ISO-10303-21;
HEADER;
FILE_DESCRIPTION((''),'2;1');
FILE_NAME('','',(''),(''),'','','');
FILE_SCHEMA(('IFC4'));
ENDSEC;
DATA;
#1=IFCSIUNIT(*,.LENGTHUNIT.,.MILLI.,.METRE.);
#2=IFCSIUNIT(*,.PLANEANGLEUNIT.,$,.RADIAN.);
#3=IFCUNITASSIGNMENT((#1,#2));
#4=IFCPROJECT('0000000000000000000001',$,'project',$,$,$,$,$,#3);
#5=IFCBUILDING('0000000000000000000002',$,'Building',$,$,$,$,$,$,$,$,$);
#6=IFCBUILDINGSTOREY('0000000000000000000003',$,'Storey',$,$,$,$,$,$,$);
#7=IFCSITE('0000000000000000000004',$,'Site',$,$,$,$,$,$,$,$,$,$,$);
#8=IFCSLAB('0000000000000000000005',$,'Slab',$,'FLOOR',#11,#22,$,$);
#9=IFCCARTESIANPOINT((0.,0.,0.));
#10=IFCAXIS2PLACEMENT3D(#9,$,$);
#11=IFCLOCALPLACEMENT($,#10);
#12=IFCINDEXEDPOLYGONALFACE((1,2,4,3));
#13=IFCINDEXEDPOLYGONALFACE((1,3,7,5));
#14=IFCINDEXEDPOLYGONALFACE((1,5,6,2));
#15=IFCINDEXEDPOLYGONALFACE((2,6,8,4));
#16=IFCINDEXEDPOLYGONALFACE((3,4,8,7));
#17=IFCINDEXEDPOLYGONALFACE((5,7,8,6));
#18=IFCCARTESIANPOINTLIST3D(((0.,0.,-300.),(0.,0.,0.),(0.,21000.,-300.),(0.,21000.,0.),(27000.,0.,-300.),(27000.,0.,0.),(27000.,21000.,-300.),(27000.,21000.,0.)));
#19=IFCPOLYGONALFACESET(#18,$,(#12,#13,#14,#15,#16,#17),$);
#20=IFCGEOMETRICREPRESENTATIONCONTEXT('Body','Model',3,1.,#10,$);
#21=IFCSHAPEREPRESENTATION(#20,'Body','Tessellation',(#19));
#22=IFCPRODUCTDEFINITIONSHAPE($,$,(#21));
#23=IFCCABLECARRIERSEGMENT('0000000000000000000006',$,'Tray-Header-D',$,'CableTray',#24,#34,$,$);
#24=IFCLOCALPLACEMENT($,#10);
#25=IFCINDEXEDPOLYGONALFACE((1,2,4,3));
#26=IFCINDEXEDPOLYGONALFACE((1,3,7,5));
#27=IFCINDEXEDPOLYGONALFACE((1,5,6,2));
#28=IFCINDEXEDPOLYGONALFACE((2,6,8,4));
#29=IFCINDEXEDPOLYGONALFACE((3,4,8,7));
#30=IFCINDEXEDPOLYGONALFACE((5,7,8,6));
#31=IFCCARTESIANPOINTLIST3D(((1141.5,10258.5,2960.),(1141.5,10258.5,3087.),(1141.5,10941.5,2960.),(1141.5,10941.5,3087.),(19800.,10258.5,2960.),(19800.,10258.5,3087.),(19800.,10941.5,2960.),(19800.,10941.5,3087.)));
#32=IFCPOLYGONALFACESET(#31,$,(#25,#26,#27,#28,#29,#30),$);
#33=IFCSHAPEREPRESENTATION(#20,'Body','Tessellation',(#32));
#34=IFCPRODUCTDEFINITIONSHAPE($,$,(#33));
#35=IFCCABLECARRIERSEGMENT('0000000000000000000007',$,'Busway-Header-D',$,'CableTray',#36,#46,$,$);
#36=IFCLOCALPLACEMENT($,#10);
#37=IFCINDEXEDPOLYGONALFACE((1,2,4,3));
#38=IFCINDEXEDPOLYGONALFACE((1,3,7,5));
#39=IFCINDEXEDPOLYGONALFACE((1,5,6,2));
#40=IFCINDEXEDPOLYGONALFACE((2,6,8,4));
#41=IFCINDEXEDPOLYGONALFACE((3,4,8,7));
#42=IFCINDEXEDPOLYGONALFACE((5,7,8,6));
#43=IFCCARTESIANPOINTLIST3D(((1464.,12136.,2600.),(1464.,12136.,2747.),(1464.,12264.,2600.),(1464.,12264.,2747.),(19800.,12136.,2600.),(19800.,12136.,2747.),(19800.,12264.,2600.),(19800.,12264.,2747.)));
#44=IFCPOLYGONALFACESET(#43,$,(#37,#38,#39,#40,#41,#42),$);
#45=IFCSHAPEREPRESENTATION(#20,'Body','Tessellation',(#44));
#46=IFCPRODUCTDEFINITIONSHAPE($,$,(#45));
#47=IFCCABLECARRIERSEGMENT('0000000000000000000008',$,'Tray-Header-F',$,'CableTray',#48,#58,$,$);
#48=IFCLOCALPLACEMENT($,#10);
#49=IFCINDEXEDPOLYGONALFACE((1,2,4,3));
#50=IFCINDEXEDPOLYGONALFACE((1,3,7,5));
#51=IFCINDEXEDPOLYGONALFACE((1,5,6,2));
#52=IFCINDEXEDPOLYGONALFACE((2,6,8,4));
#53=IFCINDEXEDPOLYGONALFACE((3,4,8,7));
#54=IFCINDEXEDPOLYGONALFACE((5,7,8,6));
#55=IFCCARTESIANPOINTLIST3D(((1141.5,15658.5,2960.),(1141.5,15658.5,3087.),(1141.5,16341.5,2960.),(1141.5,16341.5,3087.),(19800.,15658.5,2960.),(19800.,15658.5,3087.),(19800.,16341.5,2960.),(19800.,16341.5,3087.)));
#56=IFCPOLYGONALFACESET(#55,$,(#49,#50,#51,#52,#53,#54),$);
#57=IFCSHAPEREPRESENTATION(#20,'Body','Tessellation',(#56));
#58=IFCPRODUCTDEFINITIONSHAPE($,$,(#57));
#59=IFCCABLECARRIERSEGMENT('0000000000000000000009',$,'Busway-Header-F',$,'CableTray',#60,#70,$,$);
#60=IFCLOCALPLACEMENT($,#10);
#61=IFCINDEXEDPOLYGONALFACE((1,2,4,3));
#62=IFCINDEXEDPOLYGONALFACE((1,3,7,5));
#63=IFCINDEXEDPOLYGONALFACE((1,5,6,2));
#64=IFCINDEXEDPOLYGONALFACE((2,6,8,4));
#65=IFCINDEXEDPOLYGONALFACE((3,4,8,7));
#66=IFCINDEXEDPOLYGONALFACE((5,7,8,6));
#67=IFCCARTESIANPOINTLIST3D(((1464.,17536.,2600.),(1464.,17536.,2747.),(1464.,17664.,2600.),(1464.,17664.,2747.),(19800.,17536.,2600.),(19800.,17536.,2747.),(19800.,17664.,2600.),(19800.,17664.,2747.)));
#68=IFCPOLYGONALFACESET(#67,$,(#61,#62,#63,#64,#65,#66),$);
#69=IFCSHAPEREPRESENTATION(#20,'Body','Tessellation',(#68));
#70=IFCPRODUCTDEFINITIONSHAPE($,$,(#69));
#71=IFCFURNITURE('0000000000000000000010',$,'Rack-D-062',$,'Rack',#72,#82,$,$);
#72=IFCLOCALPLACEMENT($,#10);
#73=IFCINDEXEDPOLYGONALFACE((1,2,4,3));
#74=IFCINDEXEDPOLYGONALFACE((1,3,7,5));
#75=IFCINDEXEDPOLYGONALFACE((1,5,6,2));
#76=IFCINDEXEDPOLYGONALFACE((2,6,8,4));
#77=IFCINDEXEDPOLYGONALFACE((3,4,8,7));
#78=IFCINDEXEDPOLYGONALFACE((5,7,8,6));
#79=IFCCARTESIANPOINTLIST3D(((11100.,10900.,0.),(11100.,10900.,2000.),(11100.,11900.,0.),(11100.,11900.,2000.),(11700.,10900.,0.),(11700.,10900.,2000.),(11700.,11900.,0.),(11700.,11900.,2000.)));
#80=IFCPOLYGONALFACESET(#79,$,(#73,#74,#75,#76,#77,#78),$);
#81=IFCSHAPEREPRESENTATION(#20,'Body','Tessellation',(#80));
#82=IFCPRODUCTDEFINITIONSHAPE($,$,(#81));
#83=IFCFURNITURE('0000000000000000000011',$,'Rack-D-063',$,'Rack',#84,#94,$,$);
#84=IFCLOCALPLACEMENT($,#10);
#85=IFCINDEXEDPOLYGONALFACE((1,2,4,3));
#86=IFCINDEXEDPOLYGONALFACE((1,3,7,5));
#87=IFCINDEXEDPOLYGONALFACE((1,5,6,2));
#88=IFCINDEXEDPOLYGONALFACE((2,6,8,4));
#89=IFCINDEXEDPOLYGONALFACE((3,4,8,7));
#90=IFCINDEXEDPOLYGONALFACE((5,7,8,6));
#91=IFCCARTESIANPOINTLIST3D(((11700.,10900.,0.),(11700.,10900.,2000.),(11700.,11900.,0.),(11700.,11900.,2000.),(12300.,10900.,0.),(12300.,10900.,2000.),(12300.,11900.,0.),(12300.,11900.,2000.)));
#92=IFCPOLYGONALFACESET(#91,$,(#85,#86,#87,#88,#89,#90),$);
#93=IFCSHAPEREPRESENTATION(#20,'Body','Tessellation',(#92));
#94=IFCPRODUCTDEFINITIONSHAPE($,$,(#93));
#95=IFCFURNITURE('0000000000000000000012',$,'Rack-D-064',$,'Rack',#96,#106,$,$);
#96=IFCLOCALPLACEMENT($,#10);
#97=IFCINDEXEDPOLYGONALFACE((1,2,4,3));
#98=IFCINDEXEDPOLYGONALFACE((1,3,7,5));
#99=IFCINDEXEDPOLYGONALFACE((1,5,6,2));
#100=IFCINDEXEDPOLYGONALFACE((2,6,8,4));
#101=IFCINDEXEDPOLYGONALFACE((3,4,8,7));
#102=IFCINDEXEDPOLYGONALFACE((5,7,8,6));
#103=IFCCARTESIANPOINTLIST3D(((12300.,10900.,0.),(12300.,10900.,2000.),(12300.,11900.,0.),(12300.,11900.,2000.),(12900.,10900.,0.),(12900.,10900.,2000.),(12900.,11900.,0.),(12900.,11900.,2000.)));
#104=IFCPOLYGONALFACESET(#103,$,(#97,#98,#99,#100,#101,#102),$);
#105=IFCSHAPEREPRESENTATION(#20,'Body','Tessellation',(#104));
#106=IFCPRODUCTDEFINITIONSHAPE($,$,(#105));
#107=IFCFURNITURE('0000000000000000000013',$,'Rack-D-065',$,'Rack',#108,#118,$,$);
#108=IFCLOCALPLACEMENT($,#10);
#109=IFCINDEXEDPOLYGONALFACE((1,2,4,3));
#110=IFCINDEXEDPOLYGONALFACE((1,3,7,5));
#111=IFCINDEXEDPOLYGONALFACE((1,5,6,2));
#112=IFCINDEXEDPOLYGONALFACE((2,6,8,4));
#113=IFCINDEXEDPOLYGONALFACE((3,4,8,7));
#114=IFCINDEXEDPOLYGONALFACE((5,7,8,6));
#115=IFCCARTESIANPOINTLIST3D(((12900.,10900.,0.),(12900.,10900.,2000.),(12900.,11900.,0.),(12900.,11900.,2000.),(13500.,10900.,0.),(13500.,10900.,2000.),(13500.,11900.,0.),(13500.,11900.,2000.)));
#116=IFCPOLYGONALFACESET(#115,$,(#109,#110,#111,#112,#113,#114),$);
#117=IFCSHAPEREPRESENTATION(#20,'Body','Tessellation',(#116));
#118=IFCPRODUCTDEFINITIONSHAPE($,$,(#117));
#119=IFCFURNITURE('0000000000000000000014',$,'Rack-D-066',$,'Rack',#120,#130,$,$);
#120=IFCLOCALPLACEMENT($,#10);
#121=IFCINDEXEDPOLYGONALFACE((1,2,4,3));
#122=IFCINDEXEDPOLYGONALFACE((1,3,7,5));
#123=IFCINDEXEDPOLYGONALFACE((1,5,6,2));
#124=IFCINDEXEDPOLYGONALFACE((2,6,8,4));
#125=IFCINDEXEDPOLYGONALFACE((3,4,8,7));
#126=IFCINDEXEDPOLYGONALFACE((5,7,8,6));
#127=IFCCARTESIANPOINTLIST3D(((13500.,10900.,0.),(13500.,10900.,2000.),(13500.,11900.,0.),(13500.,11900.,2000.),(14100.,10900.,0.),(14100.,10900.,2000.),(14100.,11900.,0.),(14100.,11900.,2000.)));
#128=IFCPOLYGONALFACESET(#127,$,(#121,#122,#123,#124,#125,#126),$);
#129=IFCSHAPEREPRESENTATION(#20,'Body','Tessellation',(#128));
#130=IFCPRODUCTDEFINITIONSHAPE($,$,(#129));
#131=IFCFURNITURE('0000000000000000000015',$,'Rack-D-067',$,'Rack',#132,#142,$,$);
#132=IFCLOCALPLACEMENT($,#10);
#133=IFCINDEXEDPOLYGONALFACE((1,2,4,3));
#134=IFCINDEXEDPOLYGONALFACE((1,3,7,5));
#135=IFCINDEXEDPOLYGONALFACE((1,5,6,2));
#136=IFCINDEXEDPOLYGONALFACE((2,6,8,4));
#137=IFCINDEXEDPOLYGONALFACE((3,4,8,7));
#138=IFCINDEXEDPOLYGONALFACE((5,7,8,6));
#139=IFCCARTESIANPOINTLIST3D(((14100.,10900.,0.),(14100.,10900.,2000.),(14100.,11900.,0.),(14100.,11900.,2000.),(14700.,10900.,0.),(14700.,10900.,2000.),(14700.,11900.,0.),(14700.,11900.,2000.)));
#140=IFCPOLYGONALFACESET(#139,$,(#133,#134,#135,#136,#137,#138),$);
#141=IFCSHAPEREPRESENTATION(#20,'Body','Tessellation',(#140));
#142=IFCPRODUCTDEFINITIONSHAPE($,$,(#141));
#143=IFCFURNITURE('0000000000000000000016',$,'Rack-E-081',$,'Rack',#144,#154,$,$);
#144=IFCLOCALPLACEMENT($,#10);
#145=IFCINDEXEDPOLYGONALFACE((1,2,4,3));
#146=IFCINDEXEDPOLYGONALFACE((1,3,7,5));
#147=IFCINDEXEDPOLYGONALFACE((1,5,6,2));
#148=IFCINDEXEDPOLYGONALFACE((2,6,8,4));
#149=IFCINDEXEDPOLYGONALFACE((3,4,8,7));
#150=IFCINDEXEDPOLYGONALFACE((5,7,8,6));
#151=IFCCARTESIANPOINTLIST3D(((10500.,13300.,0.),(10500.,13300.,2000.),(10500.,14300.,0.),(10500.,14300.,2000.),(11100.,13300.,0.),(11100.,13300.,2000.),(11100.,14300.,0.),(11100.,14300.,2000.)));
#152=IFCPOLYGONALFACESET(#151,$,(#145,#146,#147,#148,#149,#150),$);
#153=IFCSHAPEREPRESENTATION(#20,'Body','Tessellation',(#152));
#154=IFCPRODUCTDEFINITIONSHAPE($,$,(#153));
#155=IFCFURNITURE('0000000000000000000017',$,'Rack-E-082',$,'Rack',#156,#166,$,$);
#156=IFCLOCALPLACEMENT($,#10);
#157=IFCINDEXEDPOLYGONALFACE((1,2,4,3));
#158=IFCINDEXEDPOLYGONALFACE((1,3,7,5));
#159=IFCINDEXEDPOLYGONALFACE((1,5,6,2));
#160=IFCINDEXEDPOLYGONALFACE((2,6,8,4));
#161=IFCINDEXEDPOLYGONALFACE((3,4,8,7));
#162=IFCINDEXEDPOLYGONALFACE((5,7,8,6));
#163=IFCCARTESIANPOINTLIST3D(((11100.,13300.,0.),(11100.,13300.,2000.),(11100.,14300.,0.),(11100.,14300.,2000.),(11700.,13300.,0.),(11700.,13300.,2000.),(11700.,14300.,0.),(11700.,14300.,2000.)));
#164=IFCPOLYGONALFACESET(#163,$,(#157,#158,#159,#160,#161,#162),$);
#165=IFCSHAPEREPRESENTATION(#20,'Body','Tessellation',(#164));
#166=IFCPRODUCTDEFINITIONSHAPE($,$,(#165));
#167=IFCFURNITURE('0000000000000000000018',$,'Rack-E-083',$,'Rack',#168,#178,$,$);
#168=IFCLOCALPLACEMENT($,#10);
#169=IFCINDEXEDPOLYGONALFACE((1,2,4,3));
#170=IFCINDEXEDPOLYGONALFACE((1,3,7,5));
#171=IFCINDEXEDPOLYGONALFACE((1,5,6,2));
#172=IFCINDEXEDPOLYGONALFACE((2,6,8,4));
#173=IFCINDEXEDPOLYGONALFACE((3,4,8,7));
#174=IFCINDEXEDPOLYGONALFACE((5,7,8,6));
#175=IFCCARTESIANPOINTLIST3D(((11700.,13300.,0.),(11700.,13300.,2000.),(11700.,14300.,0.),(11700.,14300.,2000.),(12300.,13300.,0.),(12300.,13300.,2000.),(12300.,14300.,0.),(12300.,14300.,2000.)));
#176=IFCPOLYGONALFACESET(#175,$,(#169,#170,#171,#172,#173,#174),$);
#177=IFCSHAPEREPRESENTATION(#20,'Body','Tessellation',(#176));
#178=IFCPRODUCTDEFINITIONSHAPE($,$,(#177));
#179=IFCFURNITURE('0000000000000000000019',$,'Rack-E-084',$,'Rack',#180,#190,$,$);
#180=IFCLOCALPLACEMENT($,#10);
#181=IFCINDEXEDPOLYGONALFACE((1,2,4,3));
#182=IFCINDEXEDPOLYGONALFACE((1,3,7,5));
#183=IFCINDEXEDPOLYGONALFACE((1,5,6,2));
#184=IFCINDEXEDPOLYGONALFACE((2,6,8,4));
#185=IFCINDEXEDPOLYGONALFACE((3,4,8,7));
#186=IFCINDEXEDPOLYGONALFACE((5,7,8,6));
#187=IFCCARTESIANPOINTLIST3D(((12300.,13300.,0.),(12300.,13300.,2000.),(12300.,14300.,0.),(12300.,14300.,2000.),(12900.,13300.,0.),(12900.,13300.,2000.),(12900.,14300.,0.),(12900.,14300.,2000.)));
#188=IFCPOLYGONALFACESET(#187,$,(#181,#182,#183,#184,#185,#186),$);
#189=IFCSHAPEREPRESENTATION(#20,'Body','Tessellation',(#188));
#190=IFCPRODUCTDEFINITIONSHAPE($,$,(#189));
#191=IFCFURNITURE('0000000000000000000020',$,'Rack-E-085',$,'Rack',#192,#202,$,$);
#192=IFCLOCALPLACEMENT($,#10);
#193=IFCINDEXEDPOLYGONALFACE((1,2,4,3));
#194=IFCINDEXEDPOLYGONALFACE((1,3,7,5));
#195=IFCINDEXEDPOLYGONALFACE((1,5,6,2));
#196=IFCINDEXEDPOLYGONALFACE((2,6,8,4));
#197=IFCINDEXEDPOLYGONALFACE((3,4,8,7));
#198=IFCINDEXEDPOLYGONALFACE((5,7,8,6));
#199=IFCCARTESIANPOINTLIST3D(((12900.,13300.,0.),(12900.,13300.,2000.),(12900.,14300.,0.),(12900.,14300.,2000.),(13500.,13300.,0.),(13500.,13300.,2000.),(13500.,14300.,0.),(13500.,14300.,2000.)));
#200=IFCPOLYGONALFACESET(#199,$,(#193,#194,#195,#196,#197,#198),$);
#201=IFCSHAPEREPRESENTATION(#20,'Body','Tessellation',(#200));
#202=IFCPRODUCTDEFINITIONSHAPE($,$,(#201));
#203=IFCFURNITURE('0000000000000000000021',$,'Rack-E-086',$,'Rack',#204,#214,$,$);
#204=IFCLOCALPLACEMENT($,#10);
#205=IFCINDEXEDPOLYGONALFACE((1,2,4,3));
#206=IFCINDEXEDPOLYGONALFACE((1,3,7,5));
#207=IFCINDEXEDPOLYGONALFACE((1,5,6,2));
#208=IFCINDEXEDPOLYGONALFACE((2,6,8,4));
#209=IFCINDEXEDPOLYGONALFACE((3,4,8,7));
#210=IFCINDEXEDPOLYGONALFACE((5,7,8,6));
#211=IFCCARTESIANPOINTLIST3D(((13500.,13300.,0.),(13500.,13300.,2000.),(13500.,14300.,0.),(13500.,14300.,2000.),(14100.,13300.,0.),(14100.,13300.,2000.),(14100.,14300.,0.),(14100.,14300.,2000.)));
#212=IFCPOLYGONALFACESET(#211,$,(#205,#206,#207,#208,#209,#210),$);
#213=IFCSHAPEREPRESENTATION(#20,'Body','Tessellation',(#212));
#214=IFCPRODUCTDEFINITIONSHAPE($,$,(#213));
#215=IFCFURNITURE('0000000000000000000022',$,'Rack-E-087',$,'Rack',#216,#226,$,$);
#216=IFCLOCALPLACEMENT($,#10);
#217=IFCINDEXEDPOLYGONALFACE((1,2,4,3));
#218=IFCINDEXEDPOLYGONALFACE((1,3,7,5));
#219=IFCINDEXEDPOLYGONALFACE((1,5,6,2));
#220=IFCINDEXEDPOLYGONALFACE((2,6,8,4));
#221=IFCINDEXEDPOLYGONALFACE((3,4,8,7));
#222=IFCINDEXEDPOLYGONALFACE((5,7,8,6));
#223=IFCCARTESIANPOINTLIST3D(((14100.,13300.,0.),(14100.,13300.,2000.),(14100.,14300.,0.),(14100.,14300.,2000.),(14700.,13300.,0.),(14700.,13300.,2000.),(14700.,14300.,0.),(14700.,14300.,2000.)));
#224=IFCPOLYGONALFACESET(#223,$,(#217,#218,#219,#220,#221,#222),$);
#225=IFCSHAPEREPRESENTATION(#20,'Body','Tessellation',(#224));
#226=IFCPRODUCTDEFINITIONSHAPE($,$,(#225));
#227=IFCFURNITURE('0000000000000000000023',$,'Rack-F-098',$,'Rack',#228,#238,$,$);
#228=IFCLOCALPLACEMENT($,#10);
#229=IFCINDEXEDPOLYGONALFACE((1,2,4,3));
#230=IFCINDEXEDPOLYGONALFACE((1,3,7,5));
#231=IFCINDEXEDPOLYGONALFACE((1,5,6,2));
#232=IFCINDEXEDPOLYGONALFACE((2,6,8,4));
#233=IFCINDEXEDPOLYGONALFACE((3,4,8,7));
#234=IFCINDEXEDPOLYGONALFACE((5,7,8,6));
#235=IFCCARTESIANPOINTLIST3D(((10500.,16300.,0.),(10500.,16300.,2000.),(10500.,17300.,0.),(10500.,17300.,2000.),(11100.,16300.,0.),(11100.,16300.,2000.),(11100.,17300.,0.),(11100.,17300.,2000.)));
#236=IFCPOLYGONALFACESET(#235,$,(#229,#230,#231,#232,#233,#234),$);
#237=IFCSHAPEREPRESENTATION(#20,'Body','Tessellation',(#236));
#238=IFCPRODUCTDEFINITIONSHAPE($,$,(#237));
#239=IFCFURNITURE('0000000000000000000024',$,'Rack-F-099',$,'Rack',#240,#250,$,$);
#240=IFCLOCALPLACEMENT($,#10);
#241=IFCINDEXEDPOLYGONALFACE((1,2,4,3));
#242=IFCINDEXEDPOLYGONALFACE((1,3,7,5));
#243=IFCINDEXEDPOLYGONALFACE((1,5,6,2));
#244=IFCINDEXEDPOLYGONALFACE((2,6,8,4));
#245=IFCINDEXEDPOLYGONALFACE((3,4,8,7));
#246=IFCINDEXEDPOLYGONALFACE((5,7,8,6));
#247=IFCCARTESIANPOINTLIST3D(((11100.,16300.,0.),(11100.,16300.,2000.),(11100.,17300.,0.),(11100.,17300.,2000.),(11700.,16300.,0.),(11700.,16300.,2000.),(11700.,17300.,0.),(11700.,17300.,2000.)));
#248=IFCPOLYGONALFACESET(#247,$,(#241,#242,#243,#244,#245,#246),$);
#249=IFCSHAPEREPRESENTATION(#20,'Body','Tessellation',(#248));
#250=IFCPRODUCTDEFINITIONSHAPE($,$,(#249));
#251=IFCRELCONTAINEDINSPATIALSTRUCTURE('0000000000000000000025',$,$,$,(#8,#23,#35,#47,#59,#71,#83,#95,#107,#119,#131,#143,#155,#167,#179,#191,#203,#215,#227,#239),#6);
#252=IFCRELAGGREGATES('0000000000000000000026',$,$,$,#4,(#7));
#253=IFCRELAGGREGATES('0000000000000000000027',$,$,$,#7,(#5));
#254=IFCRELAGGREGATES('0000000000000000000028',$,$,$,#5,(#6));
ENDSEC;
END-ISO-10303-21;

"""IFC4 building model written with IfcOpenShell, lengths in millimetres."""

from ifc_helpers import new_model, si_unit, frame, origin, place, context, project, spatial, rectangle, extrude, element, save


model = new_model("IFC4")

# Units and contexts
model_context = context("Model", 3, precision=1.0, world=origin(), identifier="Body")
ifc_project = project(units=[si_unit("LENGTHUNIT", "METRE", prefix="MILLI"), si_unit("PLANEANGLEUNIT", "RADIAN")])

# Site, building, storey
site = spatial("IfcSite", under=ifc_project, Name="Site")
building = spatial("IfcBuilding", under=site, Name="Building")
storey = spatial("IfcBuildingStorey", under=building, Name="Storey")

# Slab
slab_placement = place(None, frame((13500.0, 10500.0, -300.0), z_axis=(0.0, 0.0, 1.0), x_axis=(1.0, 0.0, 0.0)))
element("IfcSlab", 1, at=slab_placement, inside=storey, Name="Slab", ObjectType="FLOOR", context=model_context, shape_type="SweptSolid", body=[
    extrude(rectangle(XDim=27000.0, YDim=21000.0), origin(), (0.0, 0.0, 1.0), 300.0),
])

# Cable carrier segments
cable_carrier_segment_1_placement = place(None, frame((10470.8, 10600.0, 2960.0), z_axis=(0.0, 0.0, 1.0), x_axis=(1.0, 0.0, 0.0)))
element("IfcCableCarrierSegment", 2, at=cable_carrier_segment_1_placement, inside=storey, Name="Tray-Header-D", ObjectType="CableTray", context=model_context, shape_type="SweptSolid", body=[
    extrude(rectangle(XDim=18658.5, YDim=683.0), origin(), (0.0, 0.0, 1.0), 127.0),
])
cable_carrier_segment_2_placement = place(None, frame((10632.0, 12200.0, 2600.0), z_axis=(0.0, 0.0, 1.0), x_axis=(1.0, 0.0, 0.0)))
element("IfcCableCarrierSegment", 3, at=cable_carrier_segment_2_placement, inside=storey, Name="Busway-Header-D", ObjectType="CableTray", context=model_context, shape_type="SweptSolid", body=[
    extrude(rectangle(XDim=18336.0, YDim=128.0), origin(), (0.0, 0.0, 1.0), 147.0),
])
cable_carrier_segment_3_placement = place(None, frame((10470.8, 16000.0, 2960.0), z_axis=(0.0, 0.0, 1.0), x_axis=(1.0, 0.0, 0.0)))
element("IfcCableCarrierSegment", 4, at=cable_carrier_segment_3_placement, inside=storey, Name="Tray-Header-F", ObjectType="CableTray", context=model_context, shape_type="SweptSolid", body=[
    extrude(rectangle(XDim=18658.5, YDim=683.0), origin(), (0.0, 0.0, 1.0), 127.0),
])
cable_carrier_segment_4_placement = place(None, frame((10632.0, 17600.0, 2600.0), z_axis=(0.0, 0.0, 1.0), x_axis=(1.0, 0.0, 0.0)))
element("IfcCableCarrierSegment", 5, at=cable_carrier_segment_4_placement, inside=storey, Name="Busway-Header-F", ObjectType="CableTray", context=model_context, shape_type="SweptSolid", body=[
    extrude(rectangle(XDim=18336.0, YDim=128.0), origin(), (0.0, 0.0, 1.0), 147.0),
])

# Furniture
for number, where, z_axis, x_axis, name in (
    (6, (11400.0, 11400.0, 0.0), (0.0, 0.0, 1.0), (1.0, 0.0, 0.0), "Rack-D-062"),
    (7, (12000.0, 11400.0, 0.0), (0.0, 0.0, 1.0), (1.0, 0.0, 0.0), "Rack-D-063"),
    (8, (12600.0, 11400.0, 0.0), (0.0, 0.0, 1.0), (1.0, 0.0, 0.0), "Rack-D-064"),
    (9, (13200.0, 11400.0, 0.0), (0.0, 0.0, 1.0), (1.0, 0.0, 0.0), "Rack-D-065"),
    (10, (13800.0, 11400.0, 0.0), (0.0, 0.0, 1.0), (1.0, 0.0, 0.0), "Rack-D-066"),
    (11, (14400.0, 11400.0, 0.0), (0.0, 0.0, 1.0), (1.0, 0.0, 0.0), "Rack-D-067"),
    (12, (10800.0, 13800.0, 0.0), (0.0, 0.0, 1.0), (1.0, 0.0, 0.0), "Rack-E-081"),
    (13, (11400.0, 13800.0, 0.0), (0.0, 0.0, 1.0), (1.0, 0.0, 0.0), "Rack-E-082"),
    (14, (12000.0, 13800.0, 0.0), (0.0, 0.0, 1.0), (1.0, 0.0, 0.0), "Rack-E-083"),
    (15, (12600.0, 13800.0, 0.0), (0.0, 0.0, 1.0), (1.0, 0.0, 0.0), "Rack-E-084"),
    (16, (13200.0, 13800.0, 0.0), (0.0, 0.0, 1.0), (1.0, 0.0, 0.0), "Rack-E-085"),
    (17, (13800.0, 13800.0, 0.0), (0.0, 0.0, 1.0), (1.0, 0.0, 0.0), "Rack-E-086"),
    (18, (14400.0, 13800.0, 0.0), (0.0, 0.0, 1.0), (1.0, 0.0, 0.0), "Rack-E-087"),
    (19, (10800.0, 16800.0, 0.0), (0.0, 0.0, 1.0), (1.0, 0.0, 0.0), "Rack-F-098"),
    (20, (11400.0, 16800.0, 0.0), (0.0, 0.0, 1.0), (1.0, 0.0, 0.0), "Rack-F-099"),
):
    element("IfcFurniture", number, at=place(None, frame(where, z_axis=z_axis, x_axis=x_axis)), inside=storey, Name=name, ObjectType="Rack", context=model_context, shape_type="SweptSolid", body=[
        extrude(rectangle(XDim=600.0, YDim=1000.0), origin(), (0.0, 0.0, 1.0), 2000.0),
    ])

save(model, "model.ifc")
